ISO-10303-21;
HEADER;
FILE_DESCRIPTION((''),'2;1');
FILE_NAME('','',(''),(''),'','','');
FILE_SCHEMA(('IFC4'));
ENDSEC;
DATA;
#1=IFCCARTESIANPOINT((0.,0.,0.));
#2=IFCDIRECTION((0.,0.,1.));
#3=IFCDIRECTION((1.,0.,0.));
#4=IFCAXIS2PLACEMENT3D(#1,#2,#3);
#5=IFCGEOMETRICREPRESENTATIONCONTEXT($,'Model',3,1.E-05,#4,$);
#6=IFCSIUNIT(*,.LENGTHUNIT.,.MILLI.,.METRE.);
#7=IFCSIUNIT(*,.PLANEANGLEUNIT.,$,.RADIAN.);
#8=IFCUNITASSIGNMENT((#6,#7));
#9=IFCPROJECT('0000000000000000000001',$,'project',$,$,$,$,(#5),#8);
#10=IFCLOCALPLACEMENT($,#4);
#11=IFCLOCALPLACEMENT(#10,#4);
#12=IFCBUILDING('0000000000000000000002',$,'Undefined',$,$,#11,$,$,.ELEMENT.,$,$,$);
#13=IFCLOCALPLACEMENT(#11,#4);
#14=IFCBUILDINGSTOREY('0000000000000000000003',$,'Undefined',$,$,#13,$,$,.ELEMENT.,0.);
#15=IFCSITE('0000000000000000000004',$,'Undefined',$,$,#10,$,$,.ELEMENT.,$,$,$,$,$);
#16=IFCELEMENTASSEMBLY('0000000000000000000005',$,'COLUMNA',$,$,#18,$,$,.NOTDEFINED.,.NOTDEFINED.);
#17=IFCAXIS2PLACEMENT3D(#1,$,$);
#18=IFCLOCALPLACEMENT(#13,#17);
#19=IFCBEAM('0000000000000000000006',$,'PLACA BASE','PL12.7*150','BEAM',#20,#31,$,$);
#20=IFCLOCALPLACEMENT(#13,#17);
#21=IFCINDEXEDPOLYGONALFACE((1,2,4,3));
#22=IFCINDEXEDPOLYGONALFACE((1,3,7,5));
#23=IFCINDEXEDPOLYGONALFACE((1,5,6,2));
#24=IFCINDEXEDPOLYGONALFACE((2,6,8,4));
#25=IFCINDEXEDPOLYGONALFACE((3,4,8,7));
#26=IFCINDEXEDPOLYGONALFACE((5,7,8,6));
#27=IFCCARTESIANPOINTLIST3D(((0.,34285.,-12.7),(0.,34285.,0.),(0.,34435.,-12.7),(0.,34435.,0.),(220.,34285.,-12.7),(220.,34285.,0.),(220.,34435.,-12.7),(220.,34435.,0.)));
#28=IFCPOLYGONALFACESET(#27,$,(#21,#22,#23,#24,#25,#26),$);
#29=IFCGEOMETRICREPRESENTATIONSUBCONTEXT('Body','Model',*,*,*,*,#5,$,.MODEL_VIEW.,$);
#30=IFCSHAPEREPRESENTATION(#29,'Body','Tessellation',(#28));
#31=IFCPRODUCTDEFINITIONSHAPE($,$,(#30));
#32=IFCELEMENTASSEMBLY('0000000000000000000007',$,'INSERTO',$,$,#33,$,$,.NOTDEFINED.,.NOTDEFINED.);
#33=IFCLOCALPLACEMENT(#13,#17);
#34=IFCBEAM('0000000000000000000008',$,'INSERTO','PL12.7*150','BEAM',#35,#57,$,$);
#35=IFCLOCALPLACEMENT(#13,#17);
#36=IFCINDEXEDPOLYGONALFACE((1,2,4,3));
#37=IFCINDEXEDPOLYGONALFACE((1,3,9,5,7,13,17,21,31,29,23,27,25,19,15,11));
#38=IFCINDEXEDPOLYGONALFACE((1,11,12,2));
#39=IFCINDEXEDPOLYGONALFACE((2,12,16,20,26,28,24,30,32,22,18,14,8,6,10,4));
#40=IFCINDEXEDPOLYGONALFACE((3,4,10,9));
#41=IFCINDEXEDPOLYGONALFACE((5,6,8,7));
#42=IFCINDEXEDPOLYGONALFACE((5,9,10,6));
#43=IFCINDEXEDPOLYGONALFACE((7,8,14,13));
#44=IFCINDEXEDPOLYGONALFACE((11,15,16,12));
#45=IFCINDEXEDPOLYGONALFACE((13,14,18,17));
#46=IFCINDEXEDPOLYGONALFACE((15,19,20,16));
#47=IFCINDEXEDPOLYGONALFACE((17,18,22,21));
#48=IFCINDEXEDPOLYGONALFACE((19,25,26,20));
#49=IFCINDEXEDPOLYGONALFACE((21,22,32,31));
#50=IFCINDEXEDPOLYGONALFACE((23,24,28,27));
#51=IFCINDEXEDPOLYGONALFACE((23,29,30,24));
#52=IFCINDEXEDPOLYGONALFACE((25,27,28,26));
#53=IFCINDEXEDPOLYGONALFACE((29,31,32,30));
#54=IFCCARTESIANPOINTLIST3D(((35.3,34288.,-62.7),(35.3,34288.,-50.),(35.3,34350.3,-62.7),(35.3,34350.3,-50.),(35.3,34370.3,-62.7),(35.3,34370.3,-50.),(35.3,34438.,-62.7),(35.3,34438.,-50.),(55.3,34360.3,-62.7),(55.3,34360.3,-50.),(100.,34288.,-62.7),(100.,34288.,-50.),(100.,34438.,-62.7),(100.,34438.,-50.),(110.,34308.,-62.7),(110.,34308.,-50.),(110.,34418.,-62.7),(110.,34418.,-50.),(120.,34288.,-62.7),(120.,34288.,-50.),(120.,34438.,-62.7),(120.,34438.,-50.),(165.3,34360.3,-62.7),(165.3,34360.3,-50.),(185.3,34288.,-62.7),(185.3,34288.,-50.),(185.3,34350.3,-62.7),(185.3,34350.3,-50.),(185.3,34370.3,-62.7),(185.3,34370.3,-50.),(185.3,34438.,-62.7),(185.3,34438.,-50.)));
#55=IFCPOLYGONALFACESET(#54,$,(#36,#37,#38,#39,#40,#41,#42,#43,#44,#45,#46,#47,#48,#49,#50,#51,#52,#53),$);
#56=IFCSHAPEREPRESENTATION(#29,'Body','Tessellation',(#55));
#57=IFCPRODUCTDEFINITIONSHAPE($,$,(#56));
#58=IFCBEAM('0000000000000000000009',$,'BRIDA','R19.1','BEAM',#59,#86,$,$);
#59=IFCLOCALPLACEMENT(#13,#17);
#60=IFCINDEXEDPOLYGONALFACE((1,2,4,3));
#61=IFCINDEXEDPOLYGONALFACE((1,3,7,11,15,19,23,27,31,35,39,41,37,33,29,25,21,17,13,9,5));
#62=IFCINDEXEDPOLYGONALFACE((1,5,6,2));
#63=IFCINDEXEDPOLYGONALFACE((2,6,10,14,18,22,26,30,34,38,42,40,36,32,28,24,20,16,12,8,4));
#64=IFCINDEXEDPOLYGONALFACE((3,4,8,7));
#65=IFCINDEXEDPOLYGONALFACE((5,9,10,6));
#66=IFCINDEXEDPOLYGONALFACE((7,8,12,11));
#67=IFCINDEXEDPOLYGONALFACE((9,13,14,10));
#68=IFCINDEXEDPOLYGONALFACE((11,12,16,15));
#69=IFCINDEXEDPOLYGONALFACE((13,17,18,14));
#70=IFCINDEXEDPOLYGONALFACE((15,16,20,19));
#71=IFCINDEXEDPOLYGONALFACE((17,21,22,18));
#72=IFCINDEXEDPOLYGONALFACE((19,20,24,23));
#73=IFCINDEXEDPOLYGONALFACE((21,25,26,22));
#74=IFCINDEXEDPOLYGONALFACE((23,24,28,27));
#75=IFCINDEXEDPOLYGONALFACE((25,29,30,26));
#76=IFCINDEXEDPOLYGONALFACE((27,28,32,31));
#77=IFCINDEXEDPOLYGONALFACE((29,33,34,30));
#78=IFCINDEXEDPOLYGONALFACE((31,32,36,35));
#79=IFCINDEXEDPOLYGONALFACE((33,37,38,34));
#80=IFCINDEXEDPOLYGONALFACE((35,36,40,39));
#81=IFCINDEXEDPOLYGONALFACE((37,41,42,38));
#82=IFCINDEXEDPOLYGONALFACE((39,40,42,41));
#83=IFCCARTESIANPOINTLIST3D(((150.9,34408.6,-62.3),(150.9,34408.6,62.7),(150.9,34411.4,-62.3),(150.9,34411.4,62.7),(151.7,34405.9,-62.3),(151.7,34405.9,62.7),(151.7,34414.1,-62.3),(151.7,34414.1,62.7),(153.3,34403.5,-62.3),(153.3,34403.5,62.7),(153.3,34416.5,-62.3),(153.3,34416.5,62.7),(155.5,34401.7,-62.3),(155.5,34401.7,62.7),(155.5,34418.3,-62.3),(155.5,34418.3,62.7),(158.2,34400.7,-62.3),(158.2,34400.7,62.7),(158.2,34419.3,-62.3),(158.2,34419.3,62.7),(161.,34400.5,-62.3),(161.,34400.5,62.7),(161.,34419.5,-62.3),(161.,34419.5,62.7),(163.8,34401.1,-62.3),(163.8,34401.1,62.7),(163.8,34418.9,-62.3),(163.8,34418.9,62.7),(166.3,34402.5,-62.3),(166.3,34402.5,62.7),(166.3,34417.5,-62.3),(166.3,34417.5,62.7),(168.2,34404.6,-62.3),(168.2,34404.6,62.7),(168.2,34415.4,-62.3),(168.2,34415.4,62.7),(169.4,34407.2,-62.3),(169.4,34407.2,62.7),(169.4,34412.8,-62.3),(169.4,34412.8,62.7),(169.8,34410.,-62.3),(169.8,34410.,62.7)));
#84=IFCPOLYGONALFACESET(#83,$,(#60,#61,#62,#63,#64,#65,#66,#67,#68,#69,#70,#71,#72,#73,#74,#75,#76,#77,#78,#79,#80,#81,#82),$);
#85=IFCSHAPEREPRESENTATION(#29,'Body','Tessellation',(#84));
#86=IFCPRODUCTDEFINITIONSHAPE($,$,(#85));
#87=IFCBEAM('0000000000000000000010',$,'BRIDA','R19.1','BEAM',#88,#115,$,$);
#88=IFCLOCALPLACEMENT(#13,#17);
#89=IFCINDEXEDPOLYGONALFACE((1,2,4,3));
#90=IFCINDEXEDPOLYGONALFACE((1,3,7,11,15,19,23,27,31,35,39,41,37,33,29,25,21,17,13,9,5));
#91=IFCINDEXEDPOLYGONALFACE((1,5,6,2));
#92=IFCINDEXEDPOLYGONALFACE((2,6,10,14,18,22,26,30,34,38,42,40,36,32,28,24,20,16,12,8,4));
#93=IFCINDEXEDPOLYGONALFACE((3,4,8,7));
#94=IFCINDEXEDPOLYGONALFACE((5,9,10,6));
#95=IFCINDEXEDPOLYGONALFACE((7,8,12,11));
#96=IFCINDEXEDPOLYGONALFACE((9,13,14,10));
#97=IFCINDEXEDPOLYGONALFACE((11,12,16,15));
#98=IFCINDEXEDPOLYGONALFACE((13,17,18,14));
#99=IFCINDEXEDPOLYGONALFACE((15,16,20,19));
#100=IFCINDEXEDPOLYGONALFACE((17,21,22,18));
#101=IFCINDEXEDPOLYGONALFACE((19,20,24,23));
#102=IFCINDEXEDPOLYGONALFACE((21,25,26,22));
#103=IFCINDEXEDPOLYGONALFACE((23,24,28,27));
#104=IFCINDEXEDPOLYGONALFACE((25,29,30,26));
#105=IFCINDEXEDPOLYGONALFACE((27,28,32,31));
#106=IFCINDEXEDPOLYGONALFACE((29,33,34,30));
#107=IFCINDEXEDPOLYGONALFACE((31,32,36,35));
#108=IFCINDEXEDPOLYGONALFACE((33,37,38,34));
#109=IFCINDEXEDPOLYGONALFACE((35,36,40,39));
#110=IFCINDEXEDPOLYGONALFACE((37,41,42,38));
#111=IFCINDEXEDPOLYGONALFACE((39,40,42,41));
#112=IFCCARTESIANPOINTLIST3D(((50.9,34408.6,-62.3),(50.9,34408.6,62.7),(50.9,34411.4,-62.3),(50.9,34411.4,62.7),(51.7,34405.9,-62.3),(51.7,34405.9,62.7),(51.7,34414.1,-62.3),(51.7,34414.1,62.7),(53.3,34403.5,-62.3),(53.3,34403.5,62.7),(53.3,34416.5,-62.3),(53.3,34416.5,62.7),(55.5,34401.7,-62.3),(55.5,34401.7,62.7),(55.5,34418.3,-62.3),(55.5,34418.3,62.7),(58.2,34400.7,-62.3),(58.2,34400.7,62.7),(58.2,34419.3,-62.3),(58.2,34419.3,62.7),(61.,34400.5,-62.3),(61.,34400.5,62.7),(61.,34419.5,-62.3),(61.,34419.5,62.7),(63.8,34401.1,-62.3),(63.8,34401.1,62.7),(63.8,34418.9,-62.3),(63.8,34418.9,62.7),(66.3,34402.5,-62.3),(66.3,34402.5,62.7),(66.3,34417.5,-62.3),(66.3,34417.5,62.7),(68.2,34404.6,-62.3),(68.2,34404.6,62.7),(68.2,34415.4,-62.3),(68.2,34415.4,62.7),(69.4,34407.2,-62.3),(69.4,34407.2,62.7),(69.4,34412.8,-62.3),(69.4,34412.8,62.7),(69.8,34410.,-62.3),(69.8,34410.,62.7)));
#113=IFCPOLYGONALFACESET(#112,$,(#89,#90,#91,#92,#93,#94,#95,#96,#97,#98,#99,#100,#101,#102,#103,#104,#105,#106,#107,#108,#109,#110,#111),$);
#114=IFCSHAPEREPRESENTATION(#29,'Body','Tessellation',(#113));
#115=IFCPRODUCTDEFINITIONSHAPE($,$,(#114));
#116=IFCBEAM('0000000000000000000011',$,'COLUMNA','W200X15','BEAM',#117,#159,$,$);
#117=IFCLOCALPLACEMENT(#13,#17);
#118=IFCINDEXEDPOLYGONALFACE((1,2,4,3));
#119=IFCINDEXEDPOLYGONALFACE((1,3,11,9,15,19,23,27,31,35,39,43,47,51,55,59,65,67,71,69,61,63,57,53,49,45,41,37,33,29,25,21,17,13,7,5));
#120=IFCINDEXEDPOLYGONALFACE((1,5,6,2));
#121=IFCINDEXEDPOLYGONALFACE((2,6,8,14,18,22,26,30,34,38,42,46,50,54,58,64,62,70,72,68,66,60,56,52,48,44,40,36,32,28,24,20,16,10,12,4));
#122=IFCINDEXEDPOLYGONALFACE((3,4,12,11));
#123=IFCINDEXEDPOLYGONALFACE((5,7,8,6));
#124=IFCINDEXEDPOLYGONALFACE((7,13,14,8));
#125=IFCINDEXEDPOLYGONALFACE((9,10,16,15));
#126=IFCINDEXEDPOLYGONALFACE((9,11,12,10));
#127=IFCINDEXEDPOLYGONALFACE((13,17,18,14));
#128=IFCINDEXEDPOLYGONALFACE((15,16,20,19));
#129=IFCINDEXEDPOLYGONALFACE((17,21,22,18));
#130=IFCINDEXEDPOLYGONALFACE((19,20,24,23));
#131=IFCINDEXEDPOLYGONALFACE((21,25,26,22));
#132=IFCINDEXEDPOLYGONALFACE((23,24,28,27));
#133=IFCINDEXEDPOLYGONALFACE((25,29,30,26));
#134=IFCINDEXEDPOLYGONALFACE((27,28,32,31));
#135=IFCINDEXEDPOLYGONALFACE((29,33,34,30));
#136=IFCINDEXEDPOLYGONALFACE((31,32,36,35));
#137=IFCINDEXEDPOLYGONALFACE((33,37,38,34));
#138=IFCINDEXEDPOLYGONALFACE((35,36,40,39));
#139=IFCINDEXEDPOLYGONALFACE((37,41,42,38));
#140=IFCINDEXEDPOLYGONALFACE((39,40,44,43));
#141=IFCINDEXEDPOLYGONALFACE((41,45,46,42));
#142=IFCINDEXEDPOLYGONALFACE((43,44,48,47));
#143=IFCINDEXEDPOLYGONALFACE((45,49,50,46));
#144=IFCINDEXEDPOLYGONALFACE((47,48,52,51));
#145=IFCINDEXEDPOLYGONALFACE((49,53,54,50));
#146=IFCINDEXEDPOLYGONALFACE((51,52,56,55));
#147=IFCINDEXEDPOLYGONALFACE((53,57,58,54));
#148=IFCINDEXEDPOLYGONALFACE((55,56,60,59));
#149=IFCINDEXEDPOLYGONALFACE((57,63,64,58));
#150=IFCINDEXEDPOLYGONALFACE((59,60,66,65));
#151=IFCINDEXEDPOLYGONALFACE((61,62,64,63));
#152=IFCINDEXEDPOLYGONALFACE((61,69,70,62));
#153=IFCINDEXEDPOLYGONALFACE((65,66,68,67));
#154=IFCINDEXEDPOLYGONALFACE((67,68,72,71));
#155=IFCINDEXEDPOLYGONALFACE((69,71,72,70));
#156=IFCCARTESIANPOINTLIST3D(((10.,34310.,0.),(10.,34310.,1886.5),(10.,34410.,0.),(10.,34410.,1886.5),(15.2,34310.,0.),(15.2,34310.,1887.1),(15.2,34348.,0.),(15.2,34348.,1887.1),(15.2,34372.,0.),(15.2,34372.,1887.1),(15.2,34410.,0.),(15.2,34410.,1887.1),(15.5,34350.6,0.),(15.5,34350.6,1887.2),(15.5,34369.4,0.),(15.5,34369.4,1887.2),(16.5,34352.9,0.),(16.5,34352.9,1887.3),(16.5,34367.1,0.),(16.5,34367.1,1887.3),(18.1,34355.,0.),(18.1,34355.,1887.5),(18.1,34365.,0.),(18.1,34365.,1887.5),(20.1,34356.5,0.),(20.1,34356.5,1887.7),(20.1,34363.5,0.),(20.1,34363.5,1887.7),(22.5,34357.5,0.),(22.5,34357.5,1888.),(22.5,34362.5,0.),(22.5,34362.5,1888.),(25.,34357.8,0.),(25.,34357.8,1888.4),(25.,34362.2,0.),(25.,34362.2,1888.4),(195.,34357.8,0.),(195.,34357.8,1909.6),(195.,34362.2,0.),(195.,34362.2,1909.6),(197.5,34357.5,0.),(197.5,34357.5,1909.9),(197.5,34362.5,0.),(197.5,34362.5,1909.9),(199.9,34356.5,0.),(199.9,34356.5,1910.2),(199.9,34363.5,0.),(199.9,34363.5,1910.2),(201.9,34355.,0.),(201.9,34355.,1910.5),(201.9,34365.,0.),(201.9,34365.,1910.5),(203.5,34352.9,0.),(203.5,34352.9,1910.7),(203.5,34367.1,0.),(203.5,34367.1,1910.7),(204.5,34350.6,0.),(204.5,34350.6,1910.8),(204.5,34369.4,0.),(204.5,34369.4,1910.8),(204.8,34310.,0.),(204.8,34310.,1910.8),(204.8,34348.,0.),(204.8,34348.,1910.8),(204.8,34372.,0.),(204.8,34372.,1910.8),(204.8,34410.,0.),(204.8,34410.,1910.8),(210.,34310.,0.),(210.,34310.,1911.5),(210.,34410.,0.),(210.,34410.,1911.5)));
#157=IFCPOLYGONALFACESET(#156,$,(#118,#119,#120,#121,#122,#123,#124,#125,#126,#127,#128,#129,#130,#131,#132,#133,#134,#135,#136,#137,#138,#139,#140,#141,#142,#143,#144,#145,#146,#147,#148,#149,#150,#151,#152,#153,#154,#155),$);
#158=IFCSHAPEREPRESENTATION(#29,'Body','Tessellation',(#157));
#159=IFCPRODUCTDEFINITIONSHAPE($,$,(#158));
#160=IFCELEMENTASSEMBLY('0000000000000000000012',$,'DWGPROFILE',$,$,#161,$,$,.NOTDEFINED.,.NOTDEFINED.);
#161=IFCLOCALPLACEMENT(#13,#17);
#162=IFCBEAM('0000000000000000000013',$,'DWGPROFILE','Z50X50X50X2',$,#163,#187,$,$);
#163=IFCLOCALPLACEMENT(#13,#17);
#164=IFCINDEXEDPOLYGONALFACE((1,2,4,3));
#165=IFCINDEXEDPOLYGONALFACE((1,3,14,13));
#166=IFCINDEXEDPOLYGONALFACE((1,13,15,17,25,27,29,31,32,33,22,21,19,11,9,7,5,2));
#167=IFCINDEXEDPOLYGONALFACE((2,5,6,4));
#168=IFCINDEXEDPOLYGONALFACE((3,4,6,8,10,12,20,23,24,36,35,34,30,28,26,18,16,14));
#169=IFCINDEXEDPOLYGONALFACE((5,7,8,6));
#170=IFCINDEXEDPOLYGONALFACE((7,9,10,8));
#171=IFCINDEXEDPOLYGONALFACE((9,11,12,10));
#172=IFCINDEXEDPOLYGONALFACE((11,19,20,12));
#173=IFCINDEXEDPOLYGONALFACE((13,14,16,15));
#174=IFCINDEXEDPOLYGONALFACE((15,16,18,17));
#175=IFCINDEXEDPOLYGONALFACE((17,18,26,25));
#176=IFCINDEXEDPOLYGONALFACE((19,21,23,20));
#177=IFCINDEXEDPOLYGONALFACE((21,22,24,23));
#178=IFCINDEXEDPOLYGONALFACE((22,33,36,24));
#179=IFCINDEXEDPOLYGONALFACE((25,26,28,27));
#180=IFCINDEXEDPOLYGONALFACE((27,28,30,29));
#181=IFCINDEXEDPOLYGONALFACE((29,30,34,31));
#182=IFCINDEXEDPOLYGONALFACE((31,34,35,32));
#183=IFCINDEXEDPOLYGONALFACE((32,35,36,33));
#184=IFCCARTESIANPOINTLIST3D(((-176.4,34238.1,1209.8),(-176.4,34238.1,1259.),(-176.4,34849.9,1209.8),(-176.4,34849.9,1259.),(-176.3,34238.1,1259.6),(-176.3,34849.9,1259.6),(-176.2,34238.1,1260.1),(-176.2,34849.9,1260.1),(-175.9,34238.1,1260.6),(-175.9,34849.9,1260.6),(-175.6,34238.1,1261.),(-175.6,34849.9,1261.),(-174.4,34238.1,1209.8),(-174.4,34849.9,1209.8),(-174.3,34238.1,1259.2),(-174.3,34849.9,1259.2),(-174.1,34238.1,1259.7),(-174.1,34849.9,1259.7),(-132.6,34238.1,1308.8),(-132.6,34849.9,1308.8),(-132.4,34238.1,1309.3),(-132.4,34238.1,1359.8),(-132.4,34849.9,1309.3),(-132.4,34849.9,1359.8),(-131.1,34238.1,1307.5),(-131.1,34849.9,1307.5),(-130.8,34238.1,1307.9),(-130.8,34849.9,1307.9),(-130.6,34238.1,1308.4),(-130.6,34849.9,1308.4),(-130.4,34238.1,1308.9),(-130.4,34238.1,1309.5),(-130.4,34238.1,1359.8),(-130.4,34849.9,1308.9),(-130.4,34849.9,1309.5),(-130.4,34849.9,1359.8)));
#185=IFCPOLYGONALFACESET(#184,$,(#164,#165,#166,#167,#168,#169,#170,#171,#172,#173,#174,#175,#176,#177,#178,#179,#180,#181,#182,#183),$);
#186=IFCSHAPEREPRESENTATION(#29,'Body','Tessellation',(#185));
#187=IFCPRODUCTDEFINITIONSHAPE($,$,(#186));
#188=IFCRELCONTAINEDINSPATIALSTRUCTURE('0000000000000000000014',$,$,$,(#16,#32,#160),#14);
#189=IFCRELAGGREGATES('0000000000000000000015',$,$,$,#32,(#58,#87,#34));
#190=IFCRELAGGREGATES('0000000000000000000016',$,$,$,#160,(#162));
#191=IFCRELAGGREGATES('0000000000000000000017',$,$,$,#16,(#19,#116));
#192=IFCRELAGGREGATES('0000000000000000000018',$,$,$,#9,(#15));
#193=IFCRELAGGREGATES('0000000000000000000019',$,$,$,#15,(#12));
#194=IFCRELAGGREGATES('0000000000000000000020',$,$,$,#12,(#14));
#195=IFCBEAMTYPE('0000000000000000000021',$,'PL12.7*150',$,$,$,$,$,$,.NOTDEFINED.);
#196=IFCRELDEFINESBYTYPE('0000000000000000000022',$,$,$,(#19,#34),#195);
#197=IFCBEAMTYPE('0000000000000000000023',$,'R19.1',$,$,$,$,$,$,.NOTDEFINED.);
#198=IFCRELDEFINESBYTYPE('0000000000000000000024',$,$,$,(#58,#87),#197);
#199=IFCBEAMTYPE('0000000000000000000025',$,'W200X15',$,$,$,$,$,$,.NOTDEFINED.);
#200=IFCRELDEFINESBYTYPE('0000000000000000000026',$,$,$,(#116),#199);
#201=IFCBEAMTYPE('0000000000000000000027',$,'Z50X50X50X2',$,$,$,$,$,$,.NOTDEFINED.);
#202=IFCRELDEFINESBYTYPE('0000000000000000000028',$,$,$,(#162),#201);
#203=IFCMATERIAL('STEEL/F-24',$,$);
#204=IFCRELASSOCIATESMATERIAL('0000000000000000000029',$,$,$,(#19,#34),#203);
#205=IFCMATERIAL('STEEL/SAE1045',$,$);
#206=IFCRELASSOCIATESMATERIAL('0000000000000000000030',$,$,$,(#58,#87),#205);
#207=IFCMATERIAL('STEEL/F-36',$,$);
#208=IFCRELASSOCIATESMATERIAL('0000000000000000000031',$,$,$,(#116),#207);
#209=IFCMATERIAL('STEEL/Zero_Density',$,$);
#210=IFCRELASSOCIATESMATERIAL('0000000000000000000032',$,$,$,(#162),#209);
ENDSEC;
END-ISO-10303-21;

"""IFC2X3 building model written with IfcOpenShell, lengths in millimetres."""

from ifc_helpers import new_model, si_unit, frame, origin_with_axes, origin_2d_with_axis, place, context, subcontext, project, spatial, polyline, rectangle, circle, i_section, outline, extrude, boolean, clip, halfspace, material, type_object, element, aggregate, save


model = new_model("IFC2X3")

# Units and contexts
model_context = context("Model", 3, precision=1e-05, world=origin_with_axes())
body_context = subcontext(model_context, "Body", "Model", "MODEL_VIEW")
ifc_project = project(units=[si_unit("LENGTHUNIT", "METRE", prefix="MILLI"), si_unit("PLANEANGLEUNIT", "RADIAN")], contexts=[model_context])

# Site, building, storey
site_placement = place(None, origin_with_axes())
site = spatial("IfcSite", under=ifc_project, at=site_placement, Name="Undefined", CompositionType="ELEMENT")
building_placement = place(site_placement, origin_with_axes())
building = spatial("IfcBuilding", under=site, at=building_placement, Name="Undefined", CompositionType="ELEMENT")
storey_placement = place(building_placement, origin_with_axes())
storey = spatial("IfcBuildingStorey", under=building, at=storey_placement, Name="Undefined", CompositionType="ELEMENT", Elevation=0.0)

# Element assembly, beam
assembly_1_placement = place(storey_placement, origin_with_axes())
assembly_1 = element("IfcElementAssembly", 1, at=assembly_1_placement, inside=storey, Name="COLUMNA", AssemblyPlace="NOTDEFINED", PredefinedType="NOTDEFINED")
ifc_material_1 = material(Name="STEEL/F-24")
beam_type_1 = type_object("IfcBeamType", Name="PL12.7*150", PredefinedType="NOTDEFINED")
beam_1_placement = place(assembly_1_placement, frame((0.0, 34360.0, -6.4), z_axis=(0.0, -1.0, 0.0), x_axis=(1.0, 0.0, 0.0)))
beam_1 = element("IfcBeam", 2, at=beam_1_placement, type_object=beam_type_1, material=ifc_material_1, Name="PLACA BASE", Description="PL12.7*150", ObjectType="BEAM", context=body_context, shape_type="SweptSolid", body=[
    extrude(rectangle(XDim=12.7, YDim=150.0, at=origin_2d_with_axis()), frame((220.0, 0.0, 0.0), z_axis=(-1.0, 0.0, 0.0), x_axis=(0.0, -1.0, 0.0)), (0.0, 0.0, 1.0), 220.0),
])

# Element assembly, beams
assembly_2_placement = place(storey_placement, origin_with_axes())
assembly_2 = element("IfcElementAssembly", 3, at=assembly_2_placement, inside=storey, Name="INSERTO", AssemblyPlace="NOTDEFINED", PredefinedType="NOTDEFINED")
beam_2_placement = place(assembly_2_placement, frame((35.3, 34363.0, -56.3), z_axis=(0.0, 1.0, 0.0), x_axis=(1.0, 0.0, 0.0)))
beam_2 = element("IfcBeam", 4, at=beam_2_placement, type_object=beam_type_1, material=ifc_material_1, Name="INSERTO", Description="PL12.7*150", ObjectType="BEAM", context=body_context, shape_type="CSG", body=[
    boolean("DIFFERENCE", boolean("DIFFERENCE", boolean("DIFFERENCE", boolean("DIFFERENCE", extrude(rectangle(XDim=12.7, YDim=150.0, at=origin_2d_with_axis()), frame((150.0, 0.0, 0.0), z_axis=(-1.0, 0.0, 0.0), x_axis=(0.0, -1.0, 0.0)), (0.0, 0.0, 1.0), 150.0), extrude(outline(polyline([(0.0, 0.0), (20.0, 0.0), (10.0, 20.0), (0.0, 0.0)])), frame((0.0, -9.0, -12.7), z_axis=(0.0, 1.0, 0.0), x_axis=(0.0, 0.0, 1.0)), (0.0, 0.0, 1.0), 18.0)), extrude(outline(polyline([(0.0, 0.0), (20.0, 0.0), (10.0, 20.0), (0.0, 0.0)])), frame((150.0, 9.0, -12.7), z_axis=(0.0, -1.0, 0.0), x_axis=(0.0, 0.0, 1.0)), (0.0, 0.0, 1.0), 18.0)), extrude(outline(polyline([(0.0, 0.0), (20.0, 0.0), (10.0, 20.0), (0.0, 0.0)])), frame((64.7, -9.0, 75.0), z_axis=(0.0, 1.0, 0.0), x_axis=(1.0, 0.0, 0.0)), (0.0, 0.0, 1.0), 18.0)), extrude(outline(polyline([(0.0, 0.0), (20.0, 0.0), (10.0, 20.0), (0.0, 0.0)])), frame((64.7, 9.0, -75.0), z_axis=(0.0, -1.0, 0.0), x_axis=(1.0, 0.0, 0.0)), (0.0, 0.0, 1.0), 18.0)),
])
ifc_material_2 = material(Name="STEEL/SAE1045")
beam_type_2 = type_object("IfcBeamType", Name="R19.1", PredefinedType="NOTDEFINED")
beam_3_placement = place(assembly_2_placement, frame((160.3, 34410.0, -62.3), z_axis=(0.0, -1.0, 0.0), x_axis=(0.0, 0.0, 1.0)))
beam_3 = element("IfcBeam", 5, at=beam_3_placement, type_object=beam_type_2, material=ifc_material_2, Name="BRIDA", Description="R19.1", ObjectType="BEAM", context=body_context, shape_type="SweptSolid", body=[
    extrude(circle(Radius=9.6, at=origin_2d_with_axis()), frame((125.0, 0.0, 0.0), z_axis=(-1.0, 0.0, 0.0), x_axis=(0.0, -1.0, 0.0)), (0.0, 0.0, 1.0), 125.0),
])
beam_4_placement = place(assembly_2_placement, frame((60.3, 34410.0, -62.3), z_axis=(0.0, -1.0, 0.0), x_axis=(0.0, 0.0, 1.0)))
beam_4 = element("IfcBeam", 6, at=beam_4_placement, type_object=beam_type_2, material=ifc_material_2, Name="BRIDA", Description="R19.1", ObjectType="BEAM", context=body_context, shape_type="SweptSolid", body=[
    extrude(circle(Radius=9.6, at=origin_2d_with_axis()), frame((125.0, 0.0, 0.0), z_axis=(-1.0, 0.0, 0.0), x_axis=(0.0, -1.0, 0.0)), (0.0, 0.0, 1.0), 125.0),
])
aggregate(assembly_2, [beam_3, beam_4, beam_2])

# Beam
ifc_material_3 = material(Name="STEEL/F-36")
beam_type_3 = type_object("IfcBeamType", Name="W200X15", PredefinedType="NOTDEFINED")
beam_5_placement = place(assembly_1_placement, frame((110.0, 34360.0, -12.7), z_axis=(1.0, 0.0, 0.0), x_axis=(0.0, 0.0, 1.0)))
beam_5 = element("IfcBeam", 7, at=beam_5_placement, type_object=beam_type_3, material=ifc_material_3, Name="COLUMNA", Description="W200X15", ObjectType="BEAM", context=body_context, shape_type="Clipping", body=[
    clip(clip(extrude(i_section(OverallWidth=100.0, OverallDepth=200.0, WebThickness=4.3, FlangeThickness=5.2, FilletRadius=9.8, at=origin_2d_with_axis()), frame((1960.0, 0.0, 0.0), z_axis=(-1.0, 0.0, 0.0), x_axis=(0.0, -1.0, 0.0)), (0.0, 0.0, 1.0), 1960.0), halfspace(frame((1924.2, 0.0, 100.0), z_axis=(-0.992273, 0.0, 0.124075), x_axis=(0.0, -1.0, 0.0)), True)), halfspace(frame((12.7, 0.0, 0.0), z_axis=(-1.0, 0.0, 0.0), x_axis=(0.0, 1.0, 0.0)), False)),
])

# Element assembly, beam
assembly_3_placement = place(storey_placement, origin_with_axes())
assembly_3 = element("IfcElementAssembly", 8, at=assembly_3_placement, inside=storey, Name="DWGPROFILE", AssemblyPlace="NOTDEFINED", PredefinedType="NOTDEFINED")
ifc_material_4 = material(Name="STEEL/Zero_Density")
beam_type_4 = type_object("IfcBeamType", Name="Z50X50X50X2", PredefinedType="NOTDEFINED")
beam_6_placement = place(assembly_3_placement, frame((-153.4, 34849.9, 1284.8), z_axis=(0.0, 0.0, 1.0), x_axis=(0.0, -1.0, 0.0)))
beam_6 = element("IfcBeam", 9, at=beam_6_placement, type_object=beam_type_4, material=ifc_material_4, Name="DWGPROFILE", Description="Z50X50X50X2", context=body_context, shape_type="SweptSolid", body=[
    extrude(outline(polyline([(-22.9, 24.1), (-23.0, 24.7), (-23.0, 75.0), (-21.0, 75.0), (-21.0, 24.5), (-20.7, 24.0), (22.2, -23.8), (22.6, -24.2), (22.8, -24.7), (22.9, -25.2), (23.0, -25.8), (23.0, -75.0), (21.0, -75.0), (21.0, -25.6), (20.7, -25.1), (-22.2, 22.6), (-22.6, 23.1), (-22.8, 23.6), (-22.9, 24.1)])), frame((611.8, 0.0, 0.0), z_axis=(-1.0, 0.0, 0.0), x_axis=(0.0, -1.0, 0.0)), (0.0, 0.0, 1.0), 611.8),
])

aggregate(assembly_3, [beam_6])

aggregate(assembly_1, [beam_1, beam_5])

save(model, "model.ifc")
